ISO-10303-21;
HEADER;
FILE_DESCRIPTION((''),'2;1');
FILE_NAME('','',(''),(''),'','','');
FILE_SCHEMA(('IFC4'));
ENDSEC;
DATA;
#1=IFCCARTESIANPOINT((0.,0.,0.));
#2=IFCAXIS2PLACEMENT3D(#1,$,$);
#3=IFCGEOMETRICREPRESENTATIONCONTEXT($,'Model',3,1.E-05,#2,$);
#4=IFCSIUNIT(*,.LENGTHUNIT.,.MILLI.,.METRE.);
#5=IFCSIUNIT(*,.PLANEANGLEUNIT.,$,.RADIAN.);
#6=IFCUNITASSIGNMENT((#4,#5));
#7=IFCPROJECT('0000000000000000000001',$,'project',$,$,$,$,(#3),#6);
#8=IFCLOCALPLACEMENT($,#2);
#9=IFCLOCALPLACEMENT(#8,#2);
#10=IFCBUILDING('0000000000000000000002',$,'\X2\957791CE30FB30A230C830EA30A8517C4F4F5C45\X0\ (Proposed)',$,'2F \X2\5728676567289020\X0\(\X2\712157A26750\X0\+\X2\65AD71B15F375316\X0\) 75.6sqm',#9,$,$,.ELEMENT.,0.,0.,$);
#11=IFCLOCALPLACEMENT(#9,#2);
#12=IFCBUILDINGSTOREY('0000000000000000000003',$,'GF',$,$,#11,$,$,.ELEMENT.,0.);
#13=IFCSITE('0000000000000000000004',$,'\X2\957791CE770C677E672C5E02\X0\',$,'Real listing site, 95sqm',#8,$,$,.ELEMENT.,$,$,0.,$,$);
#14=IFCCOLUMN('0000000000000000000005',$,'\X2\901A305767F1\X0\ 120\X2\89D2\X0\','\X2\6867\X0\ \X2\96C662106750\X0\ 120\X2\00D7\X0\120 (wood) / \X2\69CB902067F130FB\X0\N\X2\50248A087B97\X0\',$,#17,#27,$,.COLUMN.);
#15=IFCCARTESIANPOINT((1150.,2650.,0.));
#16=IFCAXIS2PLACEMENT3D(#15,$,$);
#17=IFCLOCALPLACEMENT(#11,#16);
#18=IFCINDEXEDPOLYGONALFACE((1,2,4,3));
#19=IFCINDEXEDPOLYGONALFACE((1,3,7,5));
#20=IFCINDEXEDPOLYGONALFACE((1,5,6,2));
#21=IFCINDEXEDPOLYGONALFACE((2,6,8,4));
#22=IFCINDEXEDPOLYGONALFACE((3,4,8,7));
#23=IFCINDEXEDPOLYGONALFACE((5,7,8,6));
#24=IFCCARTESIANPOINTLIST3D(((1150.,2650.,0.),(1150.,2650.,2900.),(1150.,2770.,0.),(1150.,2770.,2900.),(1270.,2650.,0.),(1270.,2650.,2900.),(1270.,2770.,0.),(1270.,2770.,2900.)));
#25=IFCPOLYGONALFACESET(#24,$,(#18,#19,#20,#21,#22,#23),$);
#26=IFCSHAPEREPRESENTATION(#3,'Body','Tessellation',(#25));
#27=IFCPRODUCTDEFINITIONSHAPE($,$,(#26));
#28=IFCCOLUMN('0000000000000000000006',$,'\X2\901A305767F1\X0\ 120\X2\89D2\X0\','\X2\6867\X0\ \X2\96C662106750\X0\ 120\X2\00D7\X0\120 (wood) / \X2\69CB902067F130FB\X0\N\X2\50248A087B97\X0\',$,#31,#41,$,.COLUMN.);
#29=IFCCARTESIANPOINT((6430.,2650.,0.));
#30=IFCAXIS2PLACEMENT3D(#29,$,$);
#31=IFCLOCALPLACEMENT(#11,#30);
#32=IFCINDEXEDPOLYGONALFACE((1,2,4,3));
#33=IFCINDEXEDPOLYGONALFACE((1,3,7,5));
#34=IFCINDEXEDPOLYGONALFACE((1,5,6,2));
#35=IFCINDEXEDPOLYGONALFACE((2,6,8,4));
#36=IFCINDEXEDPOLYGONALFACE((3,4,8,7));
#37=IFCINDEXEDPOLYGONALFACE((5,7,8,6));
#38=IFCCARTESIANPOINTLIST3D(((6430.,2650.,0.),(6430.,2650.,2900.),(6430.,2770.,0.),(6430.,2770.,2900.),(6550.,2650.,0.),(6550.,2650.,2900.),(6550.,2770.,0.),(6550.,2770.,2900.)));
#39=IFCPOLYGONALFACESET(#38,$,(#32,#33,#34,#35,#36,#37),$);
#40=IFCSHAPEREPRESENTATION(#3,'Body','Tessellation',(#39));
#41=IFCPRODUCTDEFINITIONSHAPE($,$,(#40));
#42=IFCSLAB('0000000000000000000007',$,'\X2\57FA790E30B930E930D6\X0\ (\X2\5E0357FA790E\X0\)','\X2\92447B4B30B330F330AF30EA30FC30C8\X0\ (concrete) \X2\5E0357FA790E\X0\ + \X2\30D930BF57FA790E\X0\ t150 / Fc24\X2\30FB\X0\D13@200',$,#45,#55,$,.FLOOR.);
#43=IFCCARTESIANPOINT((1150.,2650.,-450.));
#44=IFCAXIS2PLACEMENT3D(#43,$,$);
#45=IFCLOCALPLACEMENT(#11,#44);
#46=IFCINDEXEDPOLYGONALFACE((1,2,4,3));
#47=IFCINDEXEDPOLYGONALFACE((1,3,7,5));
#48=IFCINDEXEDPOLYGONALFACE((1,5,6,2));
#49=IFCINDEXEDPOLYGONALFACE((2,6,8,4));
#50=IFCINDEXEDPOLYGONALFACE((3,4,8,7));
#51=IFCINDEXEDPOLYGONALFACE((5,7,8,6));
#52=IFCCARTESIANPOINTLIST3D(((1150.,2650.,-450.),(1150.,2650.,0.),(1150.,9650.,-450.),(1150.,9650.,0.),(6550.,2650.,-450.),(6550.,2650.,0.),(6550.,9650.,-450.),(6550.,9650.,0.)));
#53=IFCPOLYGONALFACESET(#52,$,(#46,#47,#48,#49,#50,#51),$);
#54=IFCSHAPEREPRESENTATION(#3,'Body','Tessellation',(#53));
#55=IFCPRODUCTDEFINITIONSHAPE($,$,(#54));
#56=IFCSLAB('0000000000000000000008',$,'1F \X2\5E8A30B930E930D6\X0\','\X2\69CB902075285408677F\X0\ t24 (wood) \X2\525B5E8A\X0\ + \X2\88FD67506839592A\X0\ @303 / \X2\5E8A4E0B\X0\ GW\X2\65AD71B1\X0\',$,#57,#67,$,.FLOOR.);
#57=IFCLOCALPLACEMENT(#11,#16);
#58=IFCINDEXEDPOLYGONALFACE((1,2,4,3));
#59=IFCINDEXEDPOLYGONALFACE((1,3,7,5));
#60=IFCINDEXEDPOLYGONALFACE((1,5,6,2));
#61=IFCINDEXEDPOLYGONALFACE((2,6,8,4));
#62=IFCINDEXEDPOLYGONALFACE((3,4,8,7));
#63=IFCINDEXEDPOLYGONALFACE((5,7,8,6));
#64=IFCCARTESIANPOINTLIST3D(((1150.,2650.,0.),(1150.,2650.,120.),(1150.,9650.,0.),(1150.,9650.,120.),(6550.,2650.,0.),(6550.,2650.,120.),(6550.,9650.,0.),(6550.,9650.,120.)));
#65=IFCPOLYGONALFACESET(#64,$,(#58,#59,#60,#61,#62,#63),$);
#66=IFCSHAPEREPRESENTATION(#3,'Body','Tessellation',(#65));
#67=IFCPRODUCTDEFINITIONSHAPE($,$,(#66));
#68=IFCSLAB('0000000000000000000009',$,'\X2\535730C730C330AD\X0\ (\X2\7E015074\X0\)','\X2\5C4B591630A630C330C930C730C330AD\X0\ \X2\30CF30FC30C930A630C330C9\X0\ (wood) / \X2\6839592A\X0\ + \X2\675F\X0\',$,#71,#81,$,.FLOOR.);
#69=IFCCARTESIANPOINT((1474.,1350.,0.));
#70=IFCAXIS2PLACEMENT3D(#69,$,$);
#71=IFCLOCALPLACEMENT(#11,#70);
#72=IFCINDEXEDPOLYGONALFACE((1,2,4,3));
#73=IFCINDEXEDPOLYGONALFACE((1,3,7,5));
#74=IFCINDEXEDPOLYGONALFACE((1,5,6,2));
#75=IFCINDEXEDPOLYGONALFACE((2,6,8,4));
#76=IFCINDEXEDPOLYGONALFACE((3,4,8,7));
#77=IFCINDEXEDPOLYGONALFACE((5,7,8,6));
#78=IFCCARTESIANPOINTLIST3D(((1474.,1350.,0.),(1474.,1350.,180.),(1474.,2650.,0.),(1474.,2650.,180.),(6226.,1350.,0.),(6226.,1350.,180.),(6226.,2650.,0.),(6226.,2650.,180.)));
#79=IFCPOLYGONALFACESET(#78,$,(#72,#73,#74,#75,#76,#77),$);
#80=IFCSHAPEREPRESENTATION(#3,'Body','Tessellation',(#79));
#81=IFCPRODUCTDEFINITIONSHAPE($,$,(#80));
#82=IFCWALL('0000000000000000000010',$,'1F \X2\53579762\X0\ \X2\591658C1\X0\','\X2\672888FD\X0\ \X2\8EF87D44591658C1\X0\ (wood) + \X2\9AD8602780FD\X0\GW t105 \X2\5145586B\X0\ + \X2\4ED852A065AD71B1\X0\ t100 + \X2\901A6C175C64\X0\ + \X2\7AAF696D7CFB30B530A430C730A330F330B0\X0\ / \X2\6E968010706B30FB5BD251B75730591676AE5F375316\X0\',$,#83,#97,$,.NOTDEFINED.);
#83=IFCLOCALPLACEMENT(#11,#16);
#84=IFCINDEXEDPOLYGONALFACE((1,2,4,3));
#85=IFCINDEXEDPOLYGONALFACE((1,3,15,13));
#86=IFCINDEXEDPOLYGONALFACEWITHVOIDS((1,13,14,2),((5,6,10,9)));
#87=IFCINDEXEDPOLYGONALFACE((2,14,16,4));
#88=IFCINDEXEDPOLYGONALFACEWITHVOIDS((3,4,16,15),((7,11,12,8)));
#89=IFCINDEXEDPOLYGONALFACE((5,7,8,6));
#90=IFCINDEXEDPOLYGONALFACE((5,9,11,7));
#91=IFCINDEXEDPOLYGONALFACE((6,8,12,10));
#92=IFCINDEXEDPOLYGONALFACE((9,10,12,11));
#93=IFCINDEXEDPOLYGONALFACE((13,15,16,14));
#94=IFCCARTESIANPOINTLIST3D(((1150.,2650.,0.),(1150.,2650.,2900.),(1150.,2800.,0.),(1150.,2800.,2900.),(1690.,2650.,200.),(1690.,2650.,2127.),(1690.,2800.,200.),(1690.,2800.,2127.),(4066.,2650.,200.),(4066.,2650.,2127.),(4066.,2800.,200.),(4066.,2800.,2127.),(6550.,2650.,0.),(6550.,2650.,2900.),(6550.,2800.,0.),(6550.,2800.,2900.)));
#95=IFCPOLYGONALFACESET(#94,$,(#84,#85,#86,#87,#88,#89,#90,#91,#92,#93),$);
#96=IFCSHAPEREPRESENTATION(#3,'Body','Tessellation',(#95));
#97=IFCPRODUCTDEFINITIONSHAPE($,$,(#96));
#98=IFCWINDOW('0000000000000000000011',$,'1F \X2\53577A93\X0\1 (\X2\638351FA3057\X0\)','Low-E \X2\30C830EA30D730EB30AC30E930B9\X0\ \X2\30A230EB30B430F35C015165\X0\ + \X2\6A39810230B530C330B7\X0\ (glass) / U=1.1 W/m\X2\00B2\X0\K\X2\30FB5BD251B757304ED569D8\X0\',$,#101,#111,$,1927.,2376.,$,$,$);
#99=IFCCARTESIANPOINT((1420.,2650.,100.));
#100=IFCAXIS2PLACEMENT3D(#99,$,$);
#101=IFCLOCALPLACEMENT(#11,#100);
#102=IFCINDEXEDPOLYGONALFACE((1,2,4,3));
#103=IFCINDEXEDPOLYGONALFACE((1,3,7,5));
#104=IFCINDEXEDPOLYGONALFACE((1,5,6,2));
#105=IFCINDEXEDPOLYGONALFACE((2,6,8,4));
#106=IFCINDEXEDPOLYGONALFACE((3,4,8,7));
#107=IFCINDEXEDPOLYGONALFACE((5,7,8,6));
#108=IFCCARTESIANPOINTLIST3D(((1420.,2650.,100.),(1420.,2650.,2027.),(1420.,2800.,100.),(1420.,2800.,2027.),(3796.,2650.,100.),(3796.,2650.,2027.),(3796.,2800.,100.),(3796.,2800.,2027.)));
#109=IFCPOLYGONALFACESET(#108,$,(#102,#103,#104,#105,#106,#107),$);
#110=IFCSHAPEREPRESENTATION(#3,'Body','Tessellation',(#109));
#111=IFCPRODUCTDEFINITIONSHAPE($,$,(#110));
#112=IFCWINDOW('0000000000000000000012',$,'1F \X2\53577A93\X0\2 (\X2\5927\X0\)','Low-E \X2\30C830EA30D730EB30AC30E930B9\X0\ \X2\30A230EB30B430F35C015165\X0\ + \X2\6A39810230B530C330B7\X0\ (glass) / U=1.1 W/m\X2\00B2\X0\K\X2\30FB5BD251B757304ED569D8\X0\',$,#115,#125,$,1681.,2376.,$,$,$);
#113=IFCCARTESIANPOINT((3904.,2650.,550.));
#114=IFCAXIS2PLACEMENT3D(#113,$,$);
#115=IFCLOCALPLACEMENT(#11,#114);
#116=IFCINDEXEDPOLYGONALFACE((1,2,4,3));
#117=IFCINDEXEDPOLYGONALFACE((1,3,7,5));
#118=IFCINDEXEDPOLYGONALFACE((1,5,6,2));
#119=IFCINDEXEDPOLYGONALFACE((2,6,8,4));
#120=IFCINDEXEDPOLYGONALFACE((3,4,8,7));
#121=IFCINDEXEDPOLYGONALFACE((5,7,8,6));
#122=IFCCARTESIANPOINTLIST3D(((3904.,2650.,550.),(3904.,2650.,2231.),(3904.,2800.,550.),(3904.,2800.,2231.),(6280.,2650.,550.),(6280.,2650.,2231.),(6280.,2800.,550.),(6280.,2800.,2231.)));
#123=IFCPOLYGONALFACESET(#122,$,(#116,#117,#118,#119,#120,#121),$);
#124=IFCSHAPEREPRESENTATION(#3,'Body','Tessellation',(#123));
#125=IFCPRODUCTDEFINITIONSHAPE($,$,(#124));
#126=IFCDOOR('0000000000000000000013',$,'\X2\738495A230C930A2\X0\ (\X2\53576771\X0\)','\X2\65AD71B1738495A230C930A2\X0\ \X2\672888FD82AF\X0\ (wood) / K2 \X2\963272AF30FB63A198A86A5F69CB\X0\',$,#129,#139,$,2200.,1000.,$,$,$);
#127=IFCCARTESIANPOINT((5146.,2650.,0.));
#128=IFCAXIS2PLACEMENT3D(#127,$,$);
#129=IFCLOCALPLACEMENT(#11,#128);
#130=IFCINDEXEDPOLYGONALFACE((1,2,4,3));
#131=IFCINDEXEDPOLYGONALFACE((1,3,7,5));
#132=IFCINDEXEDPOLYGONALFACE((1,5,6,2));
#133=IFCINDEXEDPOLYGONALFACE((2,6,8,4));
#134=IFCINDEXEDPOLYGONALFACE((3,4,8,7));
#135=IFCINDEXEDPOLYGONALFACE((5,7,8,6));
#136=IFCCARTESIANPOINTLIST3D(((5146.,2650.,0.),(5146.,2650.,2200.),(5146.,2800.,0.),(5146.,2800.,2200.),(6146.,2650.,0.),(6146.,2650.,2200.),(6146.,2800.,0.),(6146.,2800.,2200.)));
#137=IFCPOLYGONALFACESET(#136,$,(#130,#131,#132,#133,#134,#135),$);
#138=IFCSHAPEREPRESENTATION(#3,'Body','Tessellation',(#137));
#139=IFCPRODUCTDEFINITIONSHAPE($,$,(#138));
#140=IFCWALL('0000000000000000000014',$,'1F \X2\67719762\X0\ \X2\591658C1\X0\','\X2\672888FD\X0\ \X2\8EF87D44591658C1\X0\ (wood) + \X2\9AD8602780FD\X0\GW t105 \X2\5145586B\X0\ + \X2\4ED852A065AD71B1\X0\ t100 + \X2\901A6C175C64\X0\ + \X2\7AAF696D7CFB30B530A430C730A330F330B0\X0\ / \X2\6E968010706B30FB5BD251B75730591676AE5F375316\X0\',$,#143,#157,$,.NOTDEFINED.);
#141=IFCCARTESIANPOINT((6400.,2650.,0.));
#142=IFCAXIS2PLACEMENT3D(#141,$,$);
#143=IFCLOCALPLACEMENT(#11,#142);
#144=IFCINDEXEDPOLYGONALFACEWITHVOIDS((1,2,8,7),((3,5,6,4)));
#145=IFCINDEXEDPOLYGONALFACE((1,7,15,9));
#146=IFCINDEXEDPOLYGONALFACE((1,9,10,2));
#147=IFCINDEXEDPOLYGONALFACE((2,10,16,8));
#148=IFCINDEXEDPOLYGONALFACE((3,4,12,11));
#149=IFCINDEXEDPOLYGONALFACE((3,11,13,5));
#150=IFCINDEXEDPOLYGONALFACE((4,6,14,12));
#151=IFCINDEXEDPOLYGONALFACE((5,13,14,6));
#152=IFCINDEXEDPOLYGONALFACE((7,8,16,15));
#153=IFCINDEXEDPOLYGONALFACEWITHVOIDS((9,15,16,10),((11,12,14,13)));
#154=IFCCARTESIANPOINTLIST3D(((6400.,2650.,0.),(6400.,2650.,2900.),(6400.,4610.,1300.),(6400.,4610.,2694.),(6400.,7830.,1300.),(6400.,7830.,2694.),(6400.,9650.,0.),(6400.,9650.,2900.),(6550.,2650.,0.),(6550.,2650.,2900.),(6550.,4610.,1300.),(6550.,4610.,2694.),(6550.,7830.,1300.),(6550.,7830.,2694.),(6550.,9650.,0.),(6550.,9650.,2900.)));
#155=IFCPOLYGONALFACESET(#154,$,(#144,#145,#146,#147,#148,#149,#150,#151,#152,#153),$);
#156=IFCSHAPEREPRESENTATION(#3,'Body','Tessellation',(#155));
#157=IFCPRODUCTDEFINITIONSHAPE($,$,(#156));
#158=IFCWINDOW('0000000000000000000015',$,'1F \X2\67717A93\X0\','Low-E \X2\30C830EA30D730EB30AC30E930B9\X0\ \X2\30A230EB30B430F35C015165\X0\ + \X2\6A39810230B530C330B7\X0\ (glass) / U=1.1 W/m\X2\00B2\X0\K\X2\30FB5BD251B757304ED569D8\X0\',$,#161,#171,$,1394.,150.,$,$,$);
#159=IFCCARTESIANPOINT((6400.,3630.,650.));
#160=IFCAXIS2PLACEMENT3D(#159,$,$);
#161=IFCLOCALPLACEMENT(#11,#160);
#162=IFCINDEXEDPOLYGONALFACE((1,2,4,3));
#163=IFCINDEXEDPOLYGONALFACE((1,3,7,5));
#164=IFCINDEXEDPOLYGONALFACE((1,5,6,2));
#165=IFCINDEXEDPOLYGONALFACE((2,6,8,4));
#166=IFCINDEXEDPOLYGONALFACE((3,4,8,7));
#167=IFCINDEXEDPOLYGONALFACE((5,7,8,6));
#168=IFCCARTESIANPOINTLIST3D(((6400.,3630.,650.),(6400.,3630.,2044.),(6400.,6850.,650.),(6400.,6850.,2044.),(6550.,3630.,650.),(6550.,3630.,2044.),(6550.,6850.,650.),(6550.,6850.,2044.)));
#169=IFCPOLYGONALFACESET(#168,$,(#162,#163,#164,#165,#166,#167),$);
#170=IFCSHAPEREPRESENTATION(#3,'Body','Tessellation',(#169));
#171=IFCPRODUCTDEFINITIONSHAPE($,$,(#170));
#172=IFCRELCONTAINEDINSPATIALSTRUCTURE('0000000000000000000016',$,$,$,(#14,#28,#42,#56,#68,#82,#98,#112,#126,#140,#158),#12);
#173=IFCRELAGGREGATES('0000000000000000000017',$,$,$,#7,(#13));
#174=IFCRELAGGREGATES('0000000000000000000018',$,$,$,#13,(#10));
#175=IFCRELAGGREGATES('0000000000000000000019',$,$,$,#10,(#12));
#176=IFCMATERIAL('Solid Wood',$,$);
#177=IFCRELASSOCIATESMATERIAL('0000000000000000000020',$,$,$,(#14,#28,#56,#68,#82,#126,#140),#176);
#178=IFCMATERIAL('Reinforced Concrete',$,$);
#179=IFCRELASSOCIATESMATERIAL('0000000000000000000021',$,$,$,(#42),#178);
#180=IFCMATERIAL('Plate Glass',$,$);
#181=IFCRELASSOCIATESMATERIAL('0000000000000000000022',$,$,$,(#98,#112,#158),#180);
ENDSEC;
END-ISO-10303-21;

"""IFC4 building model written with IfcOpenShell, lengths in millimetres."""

from ifc_helpers import new_model, si_unit, frame, frame_2d, origin, place, context, project, spatial, rectangle, extrude, material, element, fill, save


model = new_model("IFC4")

# Units and contexts
model_context = context("Model", 3, precision=1e-05, world=origin())
ifc_project = project(units=[si_unit("LENGTHUNIT", "METRE", prefix="MILLI"), si_unit("PLANEANGLEUNIT", "RADIAN")], contexts=[model_context])

# Site, building, storey
site_placement = place(None, origin())
site = spatial("IfcSite", under=ifc_project, at=site_placement, Name="長野県松本市", ObjectType="Real listing site, 95sqm", CompositionType="ELEMENT", RefElevation=0.0)
building_placement = place(site_placement, origin())
building = spatial("IfcBuilding", under=site, at=building_placement, Name="長野・アトリエ兼住居 (Proposed)", ObjectType="2F 在来木造(無垢材+断熱強化) 75.6sqm", CompositionType="ELEMENT", ElevationOfRefHeight=0.0, ElevationOfTerrain=0.0)
storey_placement = place(building_placement, origin())
storey = spatial("IfcBuildingStorey", under=building, at=storey_placement, Name="GF", CompositionType="ELEMENT", Elevation=0.0)

# Columns
ifc_material_1 = material(Name="Solid Wood")
column_1_placement = place(storey_placement, frame((1150.0, 2650.0, 0.0)))
element("IfcColumn", 1, at=column_1_placement, inside=storey, material=ifc_material_1, Name="通し柱 120角", Description="桧 集成材 120×120 (wood) / 構造柱・N値計算", PredefinedType="COLUMN", context=model_context, shape_type="SweptSolid", body=[
    extrude(rectangle(XDim=120.0, YDim=120.0, at=frame_2d((60.0, 60.0))), frame((1150.0, 2650.0, 0.0)), (0.0, 0.0, 1.0), 2900.0),
])
column_2_placement = place(storey_placement, frame((6430.0, 2650.0, 0.0)))
element("IfcColumn", 2, at=column_2_placement, inside=storey, material=ifc_material_1, Name="通し柱 120角", Description="桧 集成材 120×120 (wood) / 構造柱・N値計算", PredefinedType="COLUMN", context=model_context, shape_type="SweptSolid", body=[
    extrude(rectangle(XDim=120.0, YDim=120.0, at=frame_2d((60.0, 60.0))), frame((6430.0, 2650.0, 0.0)), (0.0, 0.0, 1.0), 2900.0),
])

# Slabs
ifc_material_2 = material(Name="Reinforced Concrete")
slab_1_placement = place(storey_placement, frame((1150.0, 2650.0, -450.0)))
element("IfcSlab", 3, at=slab_1_placement, inside=storey, material=ifc_material_2, Name="基礎スラブ (布基礎)", Description="鉄筋コンクリート (concrete) 布基礎 + ベタ基礎 t150 / Fc24・D13@200", PredefinedType="FLOOR", context=model_context, shape_type="SweptSolid", body=[
    extrude(rectangle(XDim=5400.0, YDim=7000.0, at=frame_2d((2700.0, 3500.0))), frame((1150.0, 2650.0, -450.0)), (0.0, 0.0, 1.0), 450.0),
])
slab_2_placement = place(storey_placement, frame((1150.0, 2650.0, 0.0)))
element("IfcSlab", 4, at=slab_2_placement, inside=storey, material=ifc_material_1, Name="1F 床スラブ", Description="構造用合板 t24 (wood) 剛床 + 製材根太 @303 / 床下 GW断熱", PredefinedType="FLOOR", context=model_context, shape_type="SweptSolid", body=[
    extrude(rectangle(XDim=5400.0, YDim=7000.0, at=frame_2d((2700.0, 3500.0))), frame((1150.0, 2650.0, 0.0)), (0.0, 0.0, 1.0), 120.0),
])
slab_3_placement = place(storey_placement, frame((1474.0, 1350.0, 0.0)))
element("IfcSlab", 5, at=slab_3_placement, inside=storey, material=ifc_material_1, Name="南デッキ (縁側)", Description="屋外ウッドデッキ ハードウッド (wood) / 根太 + 束", PredefinedType="FLOOR", context=model_context, shape_type="SweptSolid", body=[
    extrude(rectangle(XDim=4752.0, YDim=1300.0, at=frame_2d((2376.0, 650.0))), frame((1474.0, 1350.0, 0.0)), (0.0, 0.0, 1.0), 180.0),
])

# Wall, openings, windows, door
wall_1_placement = place(storey_placement, frame((1150.0, 2650.0, 0.0)))
wall_1 = element("IfcWall", 6, at=wall_1_placement, inside=storey, material=ifc_material_1, Name="1F 南面 外壁", Description="木製 軸組外壁 (wood) + 高性能GW t105 充填 + 付加断熱 t100 + 通気層 + 窯業系サイディング / 準耐火・寒冷地外皮強化", PredefinedType="NOTDEFINED", context=model_context, shape_type="SweptSolid", body=[
    extrude(rectangle(XDim=5400.0, YDim=150.0, at=frame_2d((2700.0, 75.0))), frame((1150.0, 2650.0, 0.0)), (0.0, 0.0, 1.0), 2900.0),
])
opening_1_placement = place(storey_placement, frame((1420.0, 2650.0, 100.0)))
opening_1 = element("IfcOpeningElement", 7, at=opening_1_placement, cuts=wall_1, PredefinedType="NOTDEFINED", context=model_context, shape_type="SweptSolid", body=[
    extrude(rectangle(XDim=2376.0, YDim=150.0, at=frame_2d((1188.0, 75.0))), frame((1420.0, 2650.0, 100.0)), (0.0, 0.0, 1.0), 1927.0),
])
opening_2_placement = place(storey_placement, frame((3904.0, 2650.0, 550.0)))
opening_2 = element("IfcOpeningElement", 8, at=opening_2_placement, cuts=wall_1, PredefinedType="NOTDEFINED", context=model_context, shape_type="SweptSolid", body=[
    extrude(rectangle(XDim=2376.0, YDim=150.0, at=frame_2d((1188.0, 75.0))), frame((3904.0, 2650.0, 550.0)), (0.0, 0.0, 1.0), 1681.0),
])
opening_3_placement = place(storey_placement, frame((5146.0, 2650.0, 0.0)))
opening_3 = element("IfcOpeningElement", 9, at=opening_3_placement, cuts=wall_1, PredefinedType="NOTDEFINED", context=model_context, shape_type="SweptSolid", body=[
    extrude(rectangle(XDim=1000.0, YDim=150.0, at=frame_2d((500.0, 75.0))), frame((5146.0, 2650.0, 0.0)), (0.0, 0.0, 1.0), 2200.0),
])
ifc_material_3 = material(Name="Plate Glass")
window_1_placement = place(storey_placement, frame((1420.0, 2650.0, 100.0)))
window_1 = element("IfcWindow", 10, at=window_1_placement, inside=storey, material=ifc_material_3, Name="1F 南窓1 (掃出し)", Description="Low-E トリプルガラス アルゴン封入 + 樹脂サッシ (glass) / U=1.1 W/m²K・寒冷地仕様", OverallHeight=1927.0, OverallWidth=2376.0, context=model_context, shape_type="SweptSolid", body=[
    extrude(rectangle(XDim=2376.0, YDim=150.0, at=frame_2d((1188.0, 75.0))), frame((1420.0, 2650.0, 100.0)), (0.0, 0.0, 1.0), 1927.0),
])
fill(opening_1, window_1)
window_2_placement = place(storey_placement, frame((3904.0, 2650.0, 550.0)))
window_2 = element("IfcWindow", 11, at=window_2_placement, inside=storey, material=ifc_material_3, Name="1F 南窓2 (大)", Description="Low-E トリプルガラス アルゴン封入 + 樹脂サッシ (glass) / U=1.1 W/m²K・寒冷地仕様", OverallHeight=1681.0, OverallWidth=2376.0, context=model_context, shape_type="SweptSolid", body=[
    extrude(rectangle(XDim=2376.0, YDim=150.0, at=frame_2d((1188.0, 75.0))), frame((3904.0, 2650.0, 550.0)), (0.0, 0.0, 1.0), 1681.0),
])
fill(opening_2, window_2)
door_placement = place(storey_placement, frame((5146.0, 2650.0, 0.0)))
door = element("IfcDoor", 12, at=door_placement, inside=storey, material=ifc_material_1, Name="玄関ドア (南東)", Description="断熱玄関ドア 木製芯 (wood) / K2 防犯・採風機構", OverallHeight=2200.0, OverallWidth=1000.0, context=model_context, shape_type="SweptSolid", body=[
    extrude(rectangle(XDim=1000.0, YDim=150.0, at=frame_2d((500.0, 75.0))), frame((5146.0, 2650.0, 0.0)), (0.0, 0.0, 1.0), 2200.0),
])
fill(opening_3, door)

# Wall, opening, window
wall_2_placement = place(storey_placement, frame((6400.0, 2650.0, 0.0)))
wall_2 = element("IfcWall", 13, at=wall_2_placement, inside=storey, material=ifc_material_1, Name="1F 東面 外壁", Description="木製 軸組外壁 (wood) + 高性能GW t105 充填 + 付加断熱 t100 + 通気層 + 窯業系サイディング / 準耐火・寒冷地外皮強化", PredefinedType="NOTDEFINED", context=model_context, shape_type="SweptSolid", body=[
    extrude(rectangle(XDim=150.0, YDim=7000.0, at=frame_2d((75.0, 3500.0))), frame((6400.0, 2650.0, 0.0)), (0.0, 0.0, 1.0), 2900.0),
])
opening_4_placement = place(storey_placement, frame((6400.0, 3630.0, 650.0)))
opening_4 = element("IfcOpeningElement", 14, at=opening_4_placement, cuts=wall_2, PredefinedType="NOTDEFINED", context=model_context, shape_type="SweptSolid", body=[
    extrude(rectangle(XDim=150.0, YDim=3220.0, at=frame_2d((75.0, 1610.0))), frame((6400.0, 3630.0, 650.0)), (0.0, 0.0, 1.0), 1394.0),
])
window_3_placement = place(storey_placement, frame((6400.0, 3630.0, 650.0)))
window_3 = element("IfcWindow", 15, at=window_3_placement, inside=storey, material=ifc_material_3, Name="1F 東窓", Description="Low-E トリプルガラス アルゴン封入 + 樹脂サッシ (glass) / U=1.1 W/m²K・寒冷地仕様", OverallHeight=1394.0, OverallWidth=150.0, context=model_context, shape_type="SweptSolid", body=[
    extrude(rectangle(XDim=150.0, YDim=3220.0, at=frame_2d((75.0, 1610.0))), frame((6400.0, 3630.0, 650.0)), (0.0, 0.0, 1.0), 1394.0),
])
fill(opening_4, window_3)

save(model, "model.ifc")
